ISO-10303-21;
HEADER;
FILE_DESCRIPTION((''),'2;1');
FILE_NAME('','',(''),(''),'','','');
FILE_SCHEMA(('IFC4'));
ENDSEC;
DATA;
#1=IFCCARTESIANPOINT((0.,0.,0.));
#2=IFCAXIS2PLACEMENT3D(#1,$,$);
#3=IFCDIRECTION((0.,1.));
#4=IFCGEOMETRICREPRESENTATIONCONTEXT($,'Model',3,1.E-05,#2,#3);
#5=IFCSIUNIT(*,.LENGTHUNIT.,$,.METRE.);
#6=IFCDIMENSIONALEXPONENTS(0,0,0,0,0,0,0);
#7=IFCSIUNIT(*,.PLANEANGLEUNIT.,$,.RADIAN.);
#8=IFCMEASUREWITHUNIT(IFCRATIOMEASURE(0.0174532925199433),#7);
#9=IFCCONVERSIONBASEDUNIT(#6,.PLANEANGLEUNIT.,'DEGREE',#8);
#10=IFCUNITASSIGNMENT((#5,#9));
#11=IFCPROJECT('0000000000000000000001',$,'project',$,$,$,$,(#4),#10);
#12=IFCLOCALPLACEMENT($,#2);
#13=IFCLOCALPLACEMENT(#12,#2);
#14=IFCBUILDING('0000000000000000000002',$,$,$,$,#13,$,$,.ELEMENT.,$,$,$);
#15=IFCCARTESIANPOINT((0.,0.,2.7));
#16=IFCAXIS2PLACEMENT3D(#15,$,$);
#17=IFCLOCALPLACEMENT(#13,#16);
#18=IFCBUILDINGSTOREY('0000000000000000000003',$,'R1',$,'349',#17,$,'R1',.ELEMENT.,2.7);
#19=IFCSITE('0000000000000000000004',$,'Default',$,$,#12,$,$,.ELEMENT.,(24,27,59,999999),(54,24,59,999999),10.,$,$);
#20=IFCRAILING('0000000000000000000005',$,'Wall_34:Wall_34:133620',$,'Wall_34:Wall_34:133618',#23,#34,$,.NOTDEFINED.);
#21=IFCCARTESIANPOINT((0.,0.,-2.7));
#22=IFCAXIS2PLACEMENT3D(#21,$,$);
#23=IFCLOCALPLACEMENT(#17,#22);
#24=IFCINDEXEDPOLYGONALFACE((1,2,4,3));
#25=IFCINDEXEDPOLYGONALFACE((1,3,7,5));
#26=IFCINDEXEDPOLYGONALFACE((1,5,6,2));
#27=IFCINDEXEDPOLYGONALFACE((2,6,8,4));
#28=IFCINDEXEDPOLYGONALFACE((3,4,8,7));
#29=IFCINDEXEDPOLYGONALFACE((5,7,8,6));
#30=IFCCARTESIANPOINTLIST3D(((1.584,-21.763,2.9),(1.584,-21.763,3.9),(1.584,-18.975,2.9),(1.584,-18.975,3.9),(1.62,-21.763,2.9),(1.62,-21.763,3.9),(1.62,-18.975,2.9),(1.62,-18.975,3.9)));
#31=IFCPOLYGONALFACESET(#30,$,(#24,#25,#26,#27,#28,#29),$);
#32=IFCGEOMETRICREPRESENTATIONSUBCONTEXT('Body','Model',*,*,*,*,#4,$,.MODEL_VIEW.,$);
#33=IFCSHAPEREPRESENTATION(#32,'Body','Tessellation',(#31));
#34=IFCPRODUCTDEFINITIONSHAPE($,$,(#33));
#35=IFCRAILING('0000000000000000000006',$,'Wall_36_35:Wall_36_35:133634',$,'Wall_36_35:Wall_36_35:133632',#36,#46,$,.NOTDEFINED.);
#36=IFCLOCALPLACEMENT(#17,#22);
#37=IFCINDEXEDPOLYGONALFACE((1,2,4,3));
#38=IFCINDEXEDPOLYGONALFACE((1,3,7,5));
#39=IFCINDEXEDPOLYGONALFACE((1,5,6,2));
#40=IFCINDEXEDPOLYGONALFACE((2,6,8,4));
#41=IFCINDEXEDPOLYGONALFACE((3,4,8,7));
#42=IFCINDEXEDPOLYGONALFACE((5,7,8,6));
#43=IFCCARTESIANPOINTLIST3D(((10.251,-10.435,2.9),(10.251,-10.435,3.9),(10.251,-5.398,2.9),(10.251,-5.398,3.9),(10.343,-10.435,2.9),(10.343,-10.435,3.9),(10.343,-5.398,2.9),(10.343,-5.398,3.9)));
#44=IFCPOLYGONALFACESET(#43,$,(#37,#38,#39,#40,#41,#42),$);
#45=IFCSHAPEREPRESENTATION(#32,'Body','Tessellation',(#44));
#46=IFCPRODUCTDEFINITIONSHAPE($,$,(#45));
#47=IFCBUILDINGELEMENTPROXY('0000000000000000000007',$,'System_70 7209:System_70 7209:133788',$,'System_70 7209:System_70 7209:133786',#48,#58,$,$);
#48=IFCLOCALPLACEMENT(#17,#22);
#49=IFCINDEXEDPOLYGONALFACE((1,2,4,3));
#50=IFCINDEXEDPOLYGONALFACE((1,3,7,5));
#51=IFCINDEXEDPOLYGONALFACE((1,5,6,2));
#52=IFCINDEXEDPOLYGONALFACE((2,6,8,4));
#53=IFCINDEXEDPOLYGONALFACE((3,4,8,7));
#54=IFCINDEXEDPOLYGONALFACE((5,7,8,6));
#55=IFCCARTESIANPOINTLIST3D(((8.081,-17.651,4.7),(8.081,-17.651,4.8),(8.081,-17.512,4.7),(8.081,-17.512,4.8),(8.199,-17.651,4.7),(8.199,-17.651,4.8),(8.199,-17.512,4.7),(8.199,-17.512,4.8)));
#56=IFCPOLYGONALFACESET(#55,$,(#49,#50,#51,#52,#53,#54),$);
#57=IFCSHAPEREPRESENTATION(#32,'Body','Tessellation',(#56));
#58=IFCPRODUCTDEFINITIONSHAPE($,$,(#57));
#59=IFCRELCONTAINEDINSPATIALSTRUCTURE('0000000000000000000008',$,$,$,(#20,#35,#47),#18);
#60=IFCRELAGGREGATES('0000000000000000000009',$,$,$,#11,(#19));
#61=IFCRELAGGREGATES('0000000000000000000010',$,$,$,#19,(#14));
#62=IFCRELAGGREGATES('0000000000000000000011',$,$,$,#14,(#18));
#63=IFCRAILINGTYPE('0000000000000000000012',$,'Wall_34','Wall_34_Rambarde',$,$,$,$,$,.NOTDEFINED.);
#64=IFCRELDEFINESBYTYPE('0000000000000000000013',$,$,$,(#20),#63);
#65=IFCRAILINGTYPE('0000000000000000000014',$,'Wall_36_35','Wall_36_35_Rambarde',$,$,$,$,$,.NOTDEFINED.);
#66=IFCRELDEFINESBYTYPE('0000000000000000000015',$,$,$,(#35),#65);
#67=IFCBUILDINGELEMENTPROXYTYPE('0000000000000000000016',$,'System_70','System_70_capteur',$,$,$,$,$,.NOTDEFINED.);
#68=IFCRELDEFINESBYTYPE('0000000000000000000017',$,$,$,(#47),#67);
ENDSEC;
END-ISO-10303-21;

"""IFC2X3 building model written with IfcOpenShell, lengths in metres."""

from ifc_helpers import new_model, entity, si_unit, converted_unit, direction, frame, frame_2d, origin, place, context, subcontext, project, spatial, rectangle, extrude, source, transform, mapped, type_object, type_shapes, element, save


model = new_model("IFC2X3")

# Units and contexts
model_context = context("Model", 3, precision=1e-05, world=origin(), true_north=direction((0.0, 1.0)))
body_context = subcontext(model_context, "Body", "Model", "MODEL_VIEW")
ifc_project = project(units=[si_unit("LENGTHUNIT", "METRE"), converted_unit("PLANEANGLEUNIT", "DEGREE", entity("IfcRatioMeasure", 0.0174532925199433), si_unit("PLANEANGLEUNIT", "RADIAN"), dimensions=[0, 0, 0, 0, 0, 0, 0])], contexts=[model_context])

# Site, building, storey
site_placement = place(None, origin())
site = spatial("IfcSite", under=ifc_project, at=site_placement, Name="Default", CompositionType="ELEMENT", RefLatitude=(24, 27, 59, 999999), RefLongitude=(54, 24, 59, 999999), RefElevation=10.0)
building_placement = place(site_placement, origin())
building = spatial("IfcBuilding", under=site, at=building_placement, CompositionType="ELEMENT")
storey_placement = place(building_placement, frame((0.0, 0.0, 2.7)))
storey = spatial("IfcBuildingStorey", under=building, at=storey_placement, Name="R1", ObjectType="349", LongName="R1", CompositionType="ELEMENT", Elevation=2.7)

# Railings
railing_type_1 = type_object("IfcRailingType", Name="Wall_34", Description="Wall_34_Rambarde", PredefinedType="NOTDEFINED")
shared_shape_1 = source(origin(), body_context, "Body", "SweptSolid", [
    extrude(rectangle(XDim=0.036, YDim=2.788, at=frame_2d((0.0, 0.0), x_axis=(1.0, 0.0))), frame((1.602, -20.369, 2.9)), (0.0, 0.0, 1.0), 1.0),
])
type_shapes(railing_type_1, [shared_shape_1])
railing_1_placement = place(storey_placement, frame((0.0, 0.0, -2.7)))
element("IfcRailing", 1, at=railing_1_placement, inside=storey, type_object=railing_type_1, Name="Wall_34:Wall_34:133620", ObjectType="Wall_34:Wall_34:133618", PredefinedType="NOTDEFINED", context=body_context, shape_type="MappedRepresentation", body=[
    mapped(shared_shape_1, transform((0.0, 0.0, 0.0), scale=1.0)),
])
railing_type_2 = type_object("IfcRailingType", Name="Wall_36_35", Description="Wall_36_35_Rambarde", PredefinedType="NOTDEFINED")
shared_shape_2 = source(origin(), body_context, "Body", "SweptSolid", [
    extrude(rectangle(XDim=0.092, YDim=5.037, at=frame_2d((0.0, 0.0), x_axis=(1.0, 0.0))), frame((10.297, -7.9165, 2.9)), (0.0, 0.0, 1.0), 1.0),
])
type_shapes(railing_type_2, [shared_shape_2])
railing_2_placement = place(storey_placement, frame((0.0, 0.0, -2.7)))
element("IfcRailing", 2, at=railing_2_placement, inside=storey, type_object=railing_type_2, Name="Wall_36_35:Wall_36_35:133634", ObjectType="Wall_36_35:Wall_36_35:133632", PredefinedType="NOTDEFINED", context=body_context, shape_type="MappedRepresentation", body=[
    mapped(shared_shape_2, transform((0.0, 0.0, 0.0), scale=1.0)),
])

# Building element proxy
building_element_proxy_type_1 = type_object("IfcBuildingElementProxyType", Name="System_70", Description="System_70_capteur", PredefinedType="NOTDEFINED")
shared_shape_3 = source(origin(), body_context, "Body", "SweptSolid", [
    extrude(rectangle(XDim=0.118, YDim=0.139, at=frame_2d((0.0, 0.0), x_axis=(1.0, 0.0))), frame((8.14, -17.5815, 4.7)), (0.0, 0.0, 1.0), 0.1),
])
type_shapes(building_element_proxy_type_1, [shared_shape_3])
proxy_1_placement = place(storey_placement, frame((0.0, 0.0, -2.7)))
element("IfcBuildingElementProxy", 3, at=proxy_1_placement, inside=storey, type_object=building_element_proxy_type_1, Name="System_70 7209:System_70 7209:133788", ObjectType="System_70 7209:System_70 7209:133786", context=body_context, shape_type="MappedRepresentation", body=[
    mapped(shared_shape_3, transform((0.0, 0.0, 0.0), scale=1.0)),
])

save(model, "model.ifc")
